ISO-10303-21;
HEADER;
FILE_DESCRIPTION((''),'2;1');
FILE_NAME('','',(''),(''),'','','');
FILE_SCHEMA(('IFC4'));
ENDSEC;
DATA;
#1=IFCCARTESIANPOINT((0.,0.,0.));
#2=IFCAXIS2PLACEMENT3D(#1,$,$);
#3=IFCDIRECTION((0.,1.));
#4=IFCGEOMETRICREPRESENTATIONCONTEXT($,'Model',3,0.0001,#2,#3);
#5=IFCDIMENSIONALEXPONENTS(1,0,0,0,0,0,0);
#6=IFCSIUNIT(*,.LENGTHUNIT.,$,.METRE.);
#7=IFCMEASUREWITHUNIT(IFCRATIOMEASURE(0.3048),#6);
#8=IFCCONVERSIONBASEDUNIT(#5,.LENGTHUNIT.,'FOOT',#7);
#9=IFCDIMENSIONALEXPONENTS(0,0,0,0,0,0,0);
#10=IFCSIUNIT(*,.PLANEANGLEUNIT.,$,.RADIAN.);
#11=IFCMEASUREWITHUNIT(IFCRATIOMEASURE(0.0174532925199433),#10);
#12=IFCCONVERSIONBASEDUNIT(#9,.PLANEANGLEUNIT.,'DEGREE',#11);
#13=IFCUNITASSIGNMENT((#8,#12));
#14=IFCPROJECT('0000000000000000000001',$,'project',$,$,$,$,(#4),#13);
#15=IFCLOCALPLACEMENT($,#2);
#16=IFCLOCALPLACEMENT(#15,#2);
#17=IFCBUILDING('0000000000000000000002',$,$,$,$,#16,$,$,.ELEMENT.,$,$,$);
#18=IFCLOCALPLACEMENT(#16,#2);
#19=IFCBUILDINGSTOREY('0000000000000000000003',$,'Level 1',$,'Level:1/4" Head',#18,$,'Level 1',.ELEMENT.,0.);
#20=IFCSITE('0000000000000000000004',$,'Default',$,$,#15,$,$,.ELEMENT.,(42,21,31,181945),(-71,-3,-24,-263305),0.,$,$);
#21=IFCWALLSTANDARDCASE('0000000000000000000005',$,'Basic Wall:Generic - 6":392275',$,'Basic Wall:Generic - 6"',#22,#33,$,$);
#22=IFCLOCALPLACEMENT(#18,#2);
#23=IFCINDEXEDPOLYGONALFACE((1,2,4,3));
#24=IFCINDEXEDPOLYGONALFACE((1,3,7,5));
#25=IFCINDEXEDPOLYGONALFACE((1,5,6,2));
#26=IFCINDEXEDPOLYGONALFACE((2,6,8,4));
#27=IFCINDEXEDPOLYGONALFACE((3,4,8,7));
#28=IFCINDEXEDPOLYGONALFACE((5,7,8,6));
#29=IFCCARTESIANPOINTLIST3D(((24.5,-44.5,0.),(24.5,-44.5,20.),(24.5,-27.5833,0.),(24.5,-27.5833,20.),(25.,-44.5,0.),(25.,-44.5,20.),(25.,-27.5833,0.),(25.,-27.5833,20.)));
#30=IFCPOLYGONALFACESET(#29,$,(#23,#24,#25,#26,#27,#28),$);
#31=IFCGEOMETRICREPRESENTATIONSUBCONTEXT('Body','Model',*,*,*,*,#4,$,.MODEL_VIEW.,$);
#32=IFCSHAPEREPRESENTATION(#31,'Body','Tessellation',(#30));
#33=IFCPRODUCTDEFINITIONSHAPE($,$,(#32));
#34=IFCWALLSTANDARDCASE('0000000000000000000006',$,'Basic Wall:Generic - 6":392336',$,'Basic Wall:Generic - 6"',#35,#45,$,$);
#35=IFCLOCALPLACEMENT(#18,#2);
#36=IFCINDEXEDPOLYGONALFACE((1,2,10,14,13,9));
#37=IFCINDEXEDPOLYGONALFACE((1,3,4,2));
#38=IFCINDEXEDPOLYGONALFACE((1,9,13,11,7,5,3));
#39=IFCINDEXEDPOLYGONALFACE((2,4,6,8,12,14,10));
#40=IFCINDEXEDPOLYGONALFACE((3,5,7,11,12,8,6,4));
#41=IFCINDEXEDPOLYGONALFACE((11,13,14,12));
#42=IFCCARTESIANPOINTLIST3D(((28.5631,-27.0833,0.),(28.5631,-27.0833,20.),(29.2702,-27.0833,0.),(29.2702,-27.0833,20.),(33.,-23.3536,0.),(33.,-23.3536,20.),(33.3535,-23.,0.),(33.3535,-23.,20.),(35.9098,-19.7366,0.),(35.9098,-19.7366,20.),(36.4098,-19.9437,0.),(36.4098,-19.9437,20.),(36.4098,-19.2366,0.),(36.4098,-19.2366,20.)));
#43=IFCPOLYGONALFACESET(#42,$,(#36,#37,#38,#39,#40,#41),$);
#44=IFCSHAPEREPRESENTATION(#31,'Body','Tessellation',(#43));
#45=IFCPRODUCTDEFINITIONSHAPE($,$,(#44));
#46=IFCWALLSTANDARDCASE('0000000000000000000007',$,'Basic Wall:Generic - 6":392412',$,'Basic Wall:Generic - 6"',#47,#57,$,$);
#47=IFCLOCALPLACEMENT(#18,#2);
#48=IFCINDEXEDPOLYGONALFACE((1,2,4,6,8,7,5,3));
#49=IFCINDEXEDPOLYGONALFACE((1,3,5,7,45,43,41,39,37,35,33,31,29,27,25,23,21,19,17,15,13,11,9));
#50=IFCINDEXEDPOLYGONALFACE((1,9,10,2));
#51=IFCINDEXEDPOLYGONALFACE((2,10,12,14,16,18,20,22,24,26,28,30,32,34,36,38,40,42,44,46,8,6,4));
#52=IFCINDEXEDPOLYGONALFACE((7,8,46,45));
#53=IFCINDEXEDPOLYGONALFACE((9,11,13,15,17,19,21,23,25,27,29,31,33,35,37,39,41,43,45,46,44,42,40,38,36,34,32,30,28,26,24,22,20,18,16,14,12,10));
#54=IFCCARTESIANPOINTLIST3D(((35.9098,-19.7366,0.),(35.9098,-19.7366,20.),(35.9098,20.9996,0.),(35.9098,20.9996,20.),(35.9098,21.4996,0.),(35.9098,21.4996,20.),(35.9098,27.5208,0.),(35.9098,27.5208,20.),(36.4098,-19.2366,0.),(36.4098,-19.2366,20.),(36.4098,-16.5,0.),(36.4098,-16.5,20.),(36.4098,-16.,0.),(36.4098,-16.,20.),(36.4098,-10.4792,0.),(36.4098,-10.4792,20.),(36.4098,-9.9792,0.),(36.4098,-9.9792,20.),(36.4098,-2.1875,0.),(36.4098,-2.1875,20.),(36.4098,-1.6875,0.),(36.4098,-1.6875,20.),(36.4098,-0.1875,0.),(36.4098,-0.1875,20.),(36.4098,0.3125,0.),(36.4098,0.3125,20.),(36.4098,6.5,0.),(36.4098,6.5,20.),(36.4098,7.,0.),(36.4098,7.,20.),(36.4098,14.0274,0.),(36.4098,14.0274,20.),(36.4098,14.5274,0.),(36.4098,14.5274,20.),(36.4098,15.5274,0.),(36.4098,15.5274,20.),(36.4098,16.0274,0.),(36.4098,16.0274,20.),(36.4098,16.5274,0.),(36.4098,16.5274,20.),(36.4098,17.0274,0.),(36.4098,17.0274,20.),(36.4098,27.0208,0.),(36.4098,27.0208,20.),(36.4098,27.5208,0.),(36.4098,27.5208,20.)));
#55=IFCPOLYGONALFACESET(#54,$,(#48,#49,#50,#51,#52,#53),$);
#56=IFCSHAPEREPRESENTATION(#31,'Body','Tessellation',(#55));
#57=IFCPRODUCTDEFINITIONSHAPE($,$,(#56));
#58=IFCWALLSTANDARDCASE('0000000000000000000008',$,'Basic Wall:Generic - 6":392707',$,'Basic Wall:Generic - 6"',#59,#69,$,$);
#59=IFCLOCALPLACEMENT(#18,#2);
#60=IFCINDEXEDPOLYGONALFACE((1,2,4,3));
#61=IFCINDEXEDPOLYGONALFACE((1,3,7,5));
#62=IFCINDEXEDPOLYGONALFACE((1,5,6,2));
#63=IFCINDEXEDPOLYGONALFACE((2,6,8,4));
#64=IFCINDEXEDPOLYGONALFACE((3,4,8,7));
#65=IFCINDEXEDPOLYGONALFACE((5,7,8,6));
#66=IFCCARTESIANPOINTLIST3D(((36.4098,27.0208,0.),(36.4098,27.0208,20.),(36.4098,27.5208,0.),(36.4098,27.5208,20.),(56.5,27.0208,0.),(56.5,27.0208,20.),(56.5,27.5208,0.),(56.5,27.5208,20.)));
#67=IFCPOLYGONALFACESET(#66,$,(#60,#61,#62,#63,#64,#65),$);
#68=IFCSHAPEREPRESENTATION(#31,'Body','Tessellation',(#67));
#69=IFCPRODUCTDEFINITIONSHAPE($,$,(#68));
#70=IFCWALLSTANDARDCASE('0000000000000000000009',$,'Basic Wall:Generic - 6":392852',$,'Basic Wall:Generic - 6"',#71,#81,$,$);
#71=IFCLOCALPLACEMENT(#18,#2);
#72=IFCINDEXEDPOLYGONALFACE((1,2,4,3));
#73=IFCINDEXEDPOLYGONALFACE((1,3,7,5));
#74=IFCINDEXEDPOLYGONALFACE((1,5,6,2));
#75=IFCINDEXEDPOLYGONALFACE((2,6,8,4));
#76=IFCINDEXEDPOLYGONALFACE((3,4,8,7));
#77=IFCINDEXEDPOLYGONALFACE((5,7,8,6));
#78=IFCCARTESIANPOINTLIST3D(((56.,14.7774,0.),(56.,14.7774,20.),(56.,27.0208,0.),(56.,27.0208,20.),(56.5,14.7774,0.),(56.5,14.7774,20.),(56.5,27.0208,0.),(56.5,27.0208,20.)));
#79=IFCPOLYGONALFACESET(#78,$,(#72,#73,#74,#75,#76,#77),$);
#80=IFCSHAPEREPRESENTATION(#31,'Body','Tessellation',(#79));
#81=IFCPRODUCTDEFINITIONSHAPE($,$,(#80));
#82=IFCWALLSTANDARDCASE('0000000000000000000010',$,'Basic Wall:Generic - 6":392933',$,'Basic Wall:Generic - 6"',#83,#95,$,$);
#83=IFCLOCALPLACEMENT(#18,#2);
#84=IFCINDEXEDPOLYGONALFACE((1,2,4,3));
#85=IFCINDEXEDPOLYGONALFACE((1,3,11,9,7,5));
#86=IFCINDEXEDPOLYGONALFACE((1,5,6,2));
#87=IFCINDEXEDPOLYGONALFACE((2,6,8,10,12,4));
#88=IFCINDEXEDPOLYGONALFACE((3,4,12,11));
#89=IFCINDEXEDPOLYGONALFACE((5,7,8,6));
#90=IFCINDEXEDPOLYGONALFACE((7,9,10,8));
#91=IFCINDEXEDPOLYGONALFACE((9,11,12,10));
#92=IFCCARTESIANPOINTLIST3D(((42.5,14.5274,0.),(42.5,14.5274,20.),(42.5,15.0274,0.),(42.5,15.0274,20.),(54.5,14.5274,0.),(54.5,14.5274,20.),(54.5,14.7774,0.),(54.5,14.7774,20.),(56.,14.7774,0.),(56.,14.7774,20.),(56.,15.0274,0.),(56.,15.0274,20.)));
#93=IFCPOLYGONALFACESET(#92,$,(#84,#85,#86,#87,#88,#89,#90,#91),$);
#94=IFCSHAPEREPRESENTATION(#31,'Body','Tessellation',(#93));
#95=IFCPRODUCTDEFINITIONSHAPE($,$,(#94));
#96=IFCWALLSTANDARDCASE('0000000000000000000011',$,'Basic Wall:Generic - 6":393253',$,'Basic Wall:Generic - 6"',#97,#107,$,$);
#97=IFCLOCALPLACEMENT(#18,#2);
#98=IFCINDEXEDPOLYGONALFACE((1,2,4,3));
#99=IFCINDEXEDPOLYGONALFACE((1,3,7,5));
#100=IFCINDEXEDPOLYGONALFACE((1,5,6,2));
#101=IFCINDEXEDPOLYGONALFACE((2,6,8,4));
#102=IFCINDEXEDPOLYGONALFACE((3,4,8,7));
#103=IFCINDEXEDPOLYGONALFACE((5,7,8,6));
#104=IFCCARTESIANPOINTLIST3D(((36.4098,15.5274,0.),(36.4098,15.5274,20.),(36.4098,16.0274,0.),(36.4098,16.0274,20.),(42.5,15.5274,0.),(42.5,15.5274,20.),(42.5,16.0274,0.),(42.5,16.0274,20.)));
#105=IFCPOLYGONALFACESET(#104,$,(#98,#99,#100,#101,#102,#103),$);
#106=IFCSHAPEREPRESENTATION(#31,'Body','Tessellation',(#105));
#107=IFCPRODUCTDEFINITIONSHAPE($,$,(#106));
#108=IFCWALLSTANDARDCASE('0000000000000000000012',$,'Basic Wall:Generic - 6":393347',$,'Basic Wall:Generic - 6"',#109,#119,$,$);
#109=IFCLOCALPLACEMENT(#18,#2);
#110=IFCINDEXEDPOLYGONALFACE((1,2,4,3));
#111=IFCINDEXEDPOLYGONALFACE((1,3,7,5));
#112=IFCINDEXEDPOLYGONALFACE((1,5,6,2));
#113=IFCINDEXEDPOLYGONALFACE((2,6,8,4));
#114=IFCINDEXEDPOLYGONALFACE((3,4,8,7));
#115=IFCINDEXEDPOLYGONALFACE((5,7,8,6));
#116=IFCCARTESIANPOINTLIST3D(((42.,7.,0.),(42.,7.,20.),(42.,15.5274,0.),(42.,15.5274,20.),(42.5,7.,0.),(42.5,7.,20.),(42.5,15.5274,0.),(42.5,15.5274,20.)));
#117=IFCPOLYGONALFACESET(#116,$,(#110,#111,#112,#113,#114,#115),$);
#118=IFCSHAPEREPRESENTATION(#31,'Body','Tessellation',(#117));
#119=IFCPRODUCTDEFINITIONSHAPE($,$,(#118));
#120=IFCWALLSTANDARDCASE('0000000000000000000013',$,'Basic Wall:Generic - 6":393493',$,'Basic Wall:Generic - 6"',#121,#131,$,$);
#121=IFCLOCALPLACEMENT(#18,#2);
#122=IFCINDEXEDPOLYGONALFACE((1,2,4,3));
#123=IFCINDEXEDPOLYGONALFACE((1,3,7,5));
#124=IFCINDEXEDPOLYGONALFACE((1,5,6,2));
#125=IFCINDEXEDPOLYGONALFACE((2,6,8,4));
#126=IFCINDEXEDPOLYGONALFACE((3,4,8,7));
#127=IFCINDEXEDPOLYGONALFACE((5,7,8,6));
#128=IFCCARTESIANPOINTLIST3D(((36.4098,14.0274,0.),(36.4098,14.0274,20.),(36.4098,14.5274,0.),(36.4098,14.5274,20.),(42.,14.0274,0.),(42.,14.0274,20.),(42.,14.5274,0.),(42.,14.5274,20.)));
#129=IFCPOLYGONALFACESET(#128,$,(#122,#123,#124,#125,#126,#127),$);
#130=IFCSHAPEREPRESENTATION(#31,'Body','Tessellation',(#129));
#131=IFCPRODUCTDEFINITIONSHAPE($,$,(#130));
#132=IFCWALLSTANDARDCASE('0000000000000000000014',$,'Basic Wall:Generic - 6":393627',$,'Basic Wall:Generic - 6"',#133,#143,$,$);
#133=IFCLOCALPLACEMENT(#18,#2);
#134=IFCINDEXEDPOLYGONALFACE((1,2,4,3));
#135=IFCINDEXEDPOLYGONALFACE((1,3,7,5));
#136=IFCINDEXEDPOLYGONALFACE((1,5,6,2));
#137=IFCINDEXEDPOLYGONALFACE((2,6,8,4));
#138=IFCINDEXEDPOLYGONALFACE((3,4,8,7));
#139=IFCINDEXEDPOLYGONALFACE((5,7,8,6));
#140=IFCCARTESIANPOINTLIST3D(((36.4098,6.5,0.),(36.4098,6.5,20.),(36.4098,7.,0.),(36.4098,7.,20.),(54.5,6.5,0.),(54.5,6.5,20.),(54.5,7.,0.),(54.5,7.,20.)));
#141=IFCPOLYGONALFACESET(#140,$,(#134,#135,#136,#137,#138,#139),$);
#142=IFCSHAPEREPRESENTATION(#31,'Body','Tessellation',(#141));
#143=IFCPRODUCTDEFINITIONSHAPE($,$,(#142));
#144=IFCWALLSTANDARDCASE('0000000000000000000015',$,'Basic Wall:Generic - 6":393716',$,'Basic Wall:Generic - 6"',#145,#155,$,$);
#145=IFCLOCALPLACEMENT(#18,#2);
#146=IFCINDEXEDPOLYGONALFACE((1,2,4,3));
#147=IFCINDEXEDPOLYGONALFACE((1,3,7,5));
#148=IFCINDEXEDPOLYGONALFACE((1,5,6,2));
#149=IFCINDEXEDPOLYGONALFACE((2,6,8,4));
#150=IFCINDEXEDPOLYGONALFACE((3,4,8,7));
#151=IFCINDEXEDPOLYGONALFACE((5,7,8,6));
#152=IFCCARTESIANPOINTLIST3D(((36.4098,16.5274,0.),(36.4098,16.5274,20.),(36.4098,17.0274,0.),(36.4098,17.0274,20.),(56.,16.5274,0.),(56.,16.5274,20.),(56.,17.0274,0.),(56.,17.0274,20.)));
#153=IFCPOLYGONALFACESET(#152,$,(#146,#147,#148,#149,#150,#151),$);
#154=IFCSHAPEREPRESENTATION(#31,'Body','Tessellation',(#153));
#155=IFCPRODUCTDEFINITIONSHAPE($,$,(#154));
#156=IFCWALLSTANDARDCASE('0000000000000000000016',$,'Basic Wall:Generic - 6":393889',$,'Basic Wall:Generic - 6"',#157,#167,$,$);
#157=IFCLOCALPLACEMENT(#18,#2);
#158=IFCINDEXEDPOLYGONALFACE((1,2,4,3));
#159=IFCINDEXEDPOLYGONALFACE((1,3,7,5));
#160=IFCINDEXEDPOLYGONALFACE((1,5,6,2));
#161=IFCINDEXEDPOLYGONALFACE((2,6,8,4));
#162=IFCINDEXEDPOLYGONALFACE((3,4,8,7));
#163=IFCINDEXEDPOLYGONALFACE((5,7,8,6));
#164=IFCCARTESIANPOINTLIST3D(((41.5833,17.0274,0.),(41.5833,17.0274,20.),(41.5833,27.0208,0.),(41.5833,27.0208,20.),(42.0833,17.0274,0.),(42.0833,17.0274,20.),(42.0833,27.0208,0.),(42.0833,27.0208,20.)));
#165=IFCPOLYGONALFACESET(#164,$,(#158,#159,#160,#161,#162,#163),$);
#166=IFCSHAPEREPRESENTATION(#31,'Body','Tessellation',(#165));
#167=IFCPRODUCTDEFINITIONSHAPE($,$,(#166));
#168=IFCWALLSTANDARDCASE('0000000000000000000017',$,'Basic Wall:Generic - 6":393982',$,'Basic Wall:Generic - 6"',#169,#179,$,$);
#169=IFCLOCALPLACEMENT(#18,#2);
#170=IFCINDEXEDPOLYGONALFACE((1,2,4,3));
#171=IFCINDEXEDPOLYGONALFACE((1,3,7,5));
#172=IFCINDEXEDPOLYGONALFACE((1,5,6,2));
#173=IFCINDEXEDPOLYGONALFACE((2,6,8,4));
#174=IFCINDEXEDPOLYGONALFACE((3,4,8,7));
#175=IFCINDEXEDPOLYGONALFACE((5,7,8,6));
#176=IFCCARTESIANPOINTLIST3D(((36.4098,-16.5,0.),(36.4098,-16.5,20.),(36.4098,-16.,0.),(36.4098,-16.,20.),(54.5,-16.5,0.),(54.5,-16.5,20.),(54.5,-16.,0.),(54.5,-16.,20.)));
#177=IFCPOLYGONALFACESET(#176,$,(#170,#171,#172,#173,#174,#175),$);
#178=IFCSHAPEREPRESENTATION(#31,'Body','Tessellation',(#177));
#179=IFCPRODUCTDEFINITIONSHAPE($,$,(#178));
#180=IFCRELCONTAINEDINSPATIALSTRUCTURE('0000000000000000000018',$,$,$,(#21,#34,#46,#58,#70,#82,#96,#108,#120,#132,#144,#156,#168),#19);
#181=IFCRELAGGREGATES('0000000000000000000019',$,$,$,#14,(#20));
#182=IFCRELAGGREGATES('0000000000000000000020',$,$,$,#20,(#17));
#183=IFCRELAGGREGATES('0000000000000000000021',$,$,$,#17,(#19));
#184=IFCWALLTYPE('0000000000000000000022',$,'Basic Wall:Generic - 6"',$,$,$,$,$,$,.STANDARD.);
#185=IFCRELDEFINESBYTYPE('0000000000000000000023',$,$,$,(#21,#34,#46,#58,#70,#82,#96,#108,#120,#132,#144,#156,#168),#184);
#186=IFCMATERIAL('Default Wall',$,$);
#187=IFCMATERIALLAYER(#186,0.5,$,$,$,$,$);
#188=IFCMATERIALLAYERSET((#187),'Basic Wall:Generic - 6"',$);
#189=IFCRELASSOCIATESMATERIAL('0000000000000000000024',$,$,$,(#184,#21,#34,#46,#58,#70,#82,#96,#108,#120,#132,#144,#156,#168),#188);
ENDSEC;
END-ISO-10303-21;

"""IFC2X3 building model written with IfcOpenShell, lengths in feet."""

from ifc_helpers import new_model, entity, si_unit, converted_unit, direction, frame, frame_2d, origin, place, context, subcontext, project, spatial, polyline, rectangle, outline, extrude, material, layer, layer_set, layer_usage, type_object, element, save


model = new_model("IFC2X3")

# Units and contexts
model_context = context("Model", 3, precision=0.0001, world=origin(), true_north=direction((0.0, 1.0)))
body_context = subcontext(model_context, "Body", "Model", "MODEL_VIEW")
ifc_project = project(units=[converted_unit("LENGTHUNIT", "FOOT", entity("IfcRatioMeasure", 0.3048), si_unit("LENGTHUNIT", "METRE"), dimensions=[1, 0, 0, 0, 0, 0, 0]), converted_unit("PLANEANGLEUNIT", "DEGREE", entity("IfcRatioMeasure", 0.0174532925199433), si_unit("PLANEANGLEUNIT", "RADIAN"), dimensions=[0, 0, 0, 0, 0, 0, 0])], contexts=[model_context])

# Site, building, storey
site_placement = place(None, origin())
site = spatial("IfcSite", under=ifc_project, at=site_placement, Name="Default", CompositionType="ELEMENT", RefLatitude=(42, 21, 31, 181945), RefLongitude=(-71, -3, -24, -263305), RefElevation=0.0)
building_placement = place(site_placement, origin())
building = spatial("IfcBuilding", under=site, at=building_placement, CompositionType="ELEMENT")
storey_placement = place(building_placement, origin())
storey = spatial("IfcBuildingStorey", under=building, at=storey_placement, Name="Level 1", ObjectType="Level:1/4\" Head", LongName="Level 1", CompositionType="ELEMENT", Elevation=0.0)

# Walls
ifc_material = material(Name="Default Wall")
ifc_layer_1 = layer(ifc_material, 0.5)
ifc_layer_set_1 = layer_set([ifc_layer_1], Name="Basic Wall:Generic - 6\"")
wall_type_1 = type_object("IfcWallType", Name="Basic Wall:Generic - 6\"", PredefinedType="STANDARD", material=ifc_layer_set_1)
ifc_layer_usage_1 = layer_usage(ifc_layer_set_1, "AXIS2", "NEGATIVE", 0.25)
wall_1_placement = place(storey_placement, frame((24.75, -27.5833, 0.0), z_axis=(0.0, 0.0, 1.0), x_axis=(0.0, -1.0, 0.0)))
element("IfcWallStandardCase", 1, at=wall_1_placement, inside=storey, type_object=wall_type_1, material=ifc_layer_usage_1, Name="Basic Wall:Generic - 6\":392275", ObjectType="Basic Wall:Generic - 6\"", context=body_context, shape_type="SweptSolid", body=[
    extrude(rectangle(XDim=16.9167, YDim=0.5, at=frame_2d((8.4583, 0.0), x_axis=(-1.0, 0.0))), origin(), (0.0, 0.0, 1.0), 20.0),
])
ifc_layer_usage_2 = layer_usage(ifc_layer_set_1, "AXIS2", "NEGATIVE", 0.25)
wall_2_placement = place(storey_placement, frame((28.7399, -27.2601, 0.0), z_axis=(0.0, 0.0, 1.0), x_axis=(0.707107, 0.707107, 0.0)))
element("IfcWallStandardCase", 2, at=wall_2_placement, inside=storey, type_object=wall_type_1, material=ifc_layer_usage_2, Name="Basic Wall:Generic - 6\":392336", ObjectType="Basic Wall:Generic - 6\"", context=body_context, shape_type="SweptSolid", body=[
    extrude(outline(polyline([(10.5969, -0.25), (11.0969, 0.25), (10.3898, 0.25), (0.0, 0.25), (0.5, -0.25), (5.7746, -0.25), (6.2746, -0.25), (10.5969, -0.25)])), origin(), (0.0, 0.0, 1.0), 20.0),
])
ifc_layer_usage_3 = layer_usage(ifc_layer_set_1, "AXIS2", "NEGATIVE", 0.25)
wall_3_placement = place(storey_placement, frame((36.1598, -19.7366, 0.0), z_axis=(0.0, 0.0, 1.0), x_axis=(0.0, 1.0, 0.0)))
element("IfcWallStandardCase", 3, at=wall_3_placement, inside=storey, type_object=wall_type_1, material=ifc_layer_usage_3, Name="Basic Wall:Generic - 6\":392412", ObjectType="Basic Wall:Generic - 6\"", context=body_context, shape_type="SweptSolid", body=[
    extrude(outline(polyline([(47.2574, -0.25), (47.2574, 0.25), (41.2362, 0.25), (40.7362, 0.25), (0.0, 0.25), (0.5, -0.25), (3.2366, -0.25), (3.7366, -0.25), (9.2574, -0.25), (9.7574, -0.25), (17.5491, -0.25), (18.0491, -0.25), (19.5491, -0.25), (20.0491, -0.25), (26.2366, -0.25), (26.7366, -0.25), (33.764, -0.25), (34.264, -0.25), (35.264, -0.25), (35.764, -0.25), (36.264, -0.25), (36.764, -0.25), (46.7574, -0.25), (47.2574, -0.25)])), origin(), (0.0, 0.0, 1.0), 20.0),
])
ifc_layer_usage_4 = layer_usage(ifc_layer_set_1, "AXIS2", "NEGATIVE", 0.25)
wall_4_placement = place(storey_placement, frame((36.4098, 27.2708, 0.0)))
element("IfcWallStandardCase", 4, at=wall_4_placement, inside=storey, type_object=wall_type_1, material=ifc_layer_usage_4, Name="Basic Wall:Generic - 6\":392707", ObjectType="Basic Wall:Generic - 6\"", context=body_context, shape_type="SweptSolid", body=[
    extrude(rectangle(XDim=20.0902, YDim=0.5, at=frame_2d((10.0451, 0.0), x_axis=(-1.0, 0.0))), origin(), (0.0, 0.0, 1.0), 20.0),
])
ifc_layer_usage_5 = layer_usage(ifc_layer_set_1, "AXIS2", "NEGATIVE", 0.25)
wall_5_placement = place(storey_placement, frame((56.25, 27.0208, 0.0), z_axis=(0.0, 0.0, 1.0), x_axis=(0.0, -1.0, 0.0)))
element("IfcWallStandardCase", 5, at=wall_5_placement, inside=storey, type_object=wall_type_1, material=ifc_layer_usage_5, Name="Basic Wall:Generic - 6\":392852", ObjectType="Basic Wall:Generic - 6\"", context=body_context, shape_type="SweptSolid", body=[
    extrude(rectangle(XDim=12.2434, YDim=0.5, at=frame_2d((6.1217, 0.0), x_axis=(-1.0, 0.0))), origin(), (0.0, 0.0, 1.0), 20.0),
])
ifc_layer_usage_6 = layer_usage(ifc_layer_set_1, "AXIS2", "NEGATIVE", 0.25)
wall_6_placement = place(storey_placement, frame((56.0, 14.7774, 0.0), z_axis=(0.0, 0.0, 1.0), x_axis=(-1.0, 0.0, 0.0)))
element("IfcWallStandardCase", 6, at=wall_6_placement, inside=storey, type_object=wall_type_1, material=ifc_layer_usage_6, Name="Basic Wall:Generic - 6\":392933", ObjectType="Basic Wall:Generic - 6\"", context=body_context, shape_type="SweptSolid", body=[
    extrude(outline(polyline([(13.5, -0.25), (13.5, 0.25), (1.5, 0.25), (1.5, 0.0), (0.0, 0.0), (0.0, -0.25), (13.5, -0.25)])), origin(), (0.0, 0.0, 1.0), 20.0),
])
ifc_layer_usage_7 = layer_usage(ifc_layer_set_1, "AXIS2", "NEGATIVE", 0.25)
wall_7_placement = place(storey_placement, frame((36.4098, 15.7774, 0.0)))
element("IfcWallStandardCase", 7, at=wall_7_placement, inside=storey, type_object=wall_type_1, material=ifc_layer_usage_7, Name="Basic Wall:Generic - 6\":393253", ObjectType="Basic Wall:Generic - 6\"", context=body_context, shape_type="SweptSolid", body=[
    extrude(rectangle(XDim=6.0902, YDim=0.5, at=frame_2d((3.0451, 0.0), x_axis=(-1.0, 0.0))), origin(), (0.0, 0.0, 1.0), 20.0),
])
ifc_layer_usage_8 = layer_usage(ifc_layer_set_1, "AXIS2", "NEGATIVE", 0.25)
wall_8_placement = place(storey_placement, frame((42.25, 15.5274, 0.0), z_axis=(0.0, 0.0, 1.0), x_axis=(0.0, -1.0, 0.0)))
element("IfcWallStandardCase", 8, at=wall_8_placement, inside=storey, type_object=wall_type_1, material=ifc_layer_usage_8, Name="Basic Wall:Generic - 6\":393347", ObjectType="Basic Wall:Generic - 6\"", context=body_context, shape_type="SweptSolid", body=[
    extrude(rectangle(XDim=8.5274, YDim=0.5, at=frame_2d((4.2637, 0.0), x_axis=(-1.0, 0.0))), origin(), (0.0, 0.0, 1.0), 20.0),
])
ifc_layer_usage_9 = layer_usage(ifc_layer_set_1, "AXIS2", "NEGATIVE", 0.25)
wall_9_placement = place(storey_placement, frame((36.4098, 14.2774, 0.0)))
element("IfcWallStandardCase", 9, at=wall_9_placement, inside=storey, type_object=wall_type_1, material=ifc_layer_usage_9, Name="Basic Wall:Generic - 6\":393493", ObjectType="Basic Wall:Generic - 6\"", context=body_context, shape_type="SweptSolid", body=[
    extrude(rectangle(XDim=5.5902, YDim=0.5, at=frame_2d((2.7951, 0.0), x_axis=(-1.0, 0.0))), origin(), (0.0, 0.0, 1.0), 20.0),
])
ifc_layer_usage_10 = layer_usage(ifc_layer_set_1, "AXIS2", "NEGATIVE", 0.25)
wall_10_placement = place(storey_placement, frame((36.4098, 6.75, 0.0)))
element("IfcWallStandardCase", 10, at=wall_10_placement, inside=storey, type_object=wall_type_1, material=ifc_layer_usage_10, Name="Basic Wall:Generic - 6\":393627", ObjectType="Basic Wall:Generic - 6\"", context=body_context, shape_type="SweptSolid", body=[
    extrude(rectangle(XDim=18.0902, YDim=0.5, at=frame_2d((9.0451, 0.0), x_axis=(-1.0, 0.0))), origin(), (0.0, 0.0, 1.0), 20.0),
])
ifc_layer_usage_11 = layer_usage(ifc_layer_set_1, "AXIS2", "NEGATIVE", 0.25)
wall_11_placement = place(storey_placement, frame((36.4098, 16.7774, 0.0)))
element("IfcWallStandardCase", 11, at=wall_11_placement, inside=storey, type_object=wall_type_1, material=ifc_layer_usage_11, Name="Basic Wall:Generic - 6\":393716", ObjectType="Basic Wall:Generic - 6\"", context=body_context, shape_type="SweptSolid", body=[
    extrude(rectangle(XDim=19.5902, YDim=0.5, at=frame_2d((9.7951, 0.0), x_axis=(-1.0, 0.0))), origin(), (0.0, 0.0, 1.0), 20.0),
])
ifc_layer_usage_12 = layer_usage(ifc_layer_set_1, "AXIS2", "NEGATIVE", 0.25)
wall_12_placement = place(storey_placement, frame((41.8333, 17.0274, 0.0), z_axis=(0.0, 0.0, 1.0), x_axis=(0.0, 1.0, 0.0)))
element("IfcWallStandardCase", 12, at=wall_12_placement, inside=storey, type_object=wall_type_1, material=ifc_layer_usage_12, Name="Basic Wall:Generic - 6\":393889", ObjectType="Basic Wall:Generic - 6\"", context=body_context, shape_type="SweptSolid", body=[
    extrude(rectangle(XDim=9.9934, YDim=0.5, at=frame_2d((4.9967, 0.0), x_axis=(-1.0, 0.0))), origin(), (0.0, 0.0, 1.0), 20.0),
])
ifc_layer_usage_13 = layer_usage(ifc_layer_set_1, "AXIS2", "NEGATIVE", 0.25)
wall_13_placement = place(storey_placement, frame((36.4098, -16.25, 0.0)))
element("IfcWallStandardCase", 13, at=wall_13_placement, inside=storey, type_object=wall_type_1, material=ifc_layer_usage_13, Name="Basic Wall:Generic - 6\":393982", ObjectType="Basic Wall:Generic - 6\"", context=body_context, shape_type="SweptSolid", body=[
    extrude(rectangle(XDim=18.0902, YDim=0.5, at=frame_2d((9.0451, 0.0), x_axis=(-1.0, 0.0))), origin(), (0.0, 0.0, 1.0), 20.0),
])

save(model, "model.ifc")
